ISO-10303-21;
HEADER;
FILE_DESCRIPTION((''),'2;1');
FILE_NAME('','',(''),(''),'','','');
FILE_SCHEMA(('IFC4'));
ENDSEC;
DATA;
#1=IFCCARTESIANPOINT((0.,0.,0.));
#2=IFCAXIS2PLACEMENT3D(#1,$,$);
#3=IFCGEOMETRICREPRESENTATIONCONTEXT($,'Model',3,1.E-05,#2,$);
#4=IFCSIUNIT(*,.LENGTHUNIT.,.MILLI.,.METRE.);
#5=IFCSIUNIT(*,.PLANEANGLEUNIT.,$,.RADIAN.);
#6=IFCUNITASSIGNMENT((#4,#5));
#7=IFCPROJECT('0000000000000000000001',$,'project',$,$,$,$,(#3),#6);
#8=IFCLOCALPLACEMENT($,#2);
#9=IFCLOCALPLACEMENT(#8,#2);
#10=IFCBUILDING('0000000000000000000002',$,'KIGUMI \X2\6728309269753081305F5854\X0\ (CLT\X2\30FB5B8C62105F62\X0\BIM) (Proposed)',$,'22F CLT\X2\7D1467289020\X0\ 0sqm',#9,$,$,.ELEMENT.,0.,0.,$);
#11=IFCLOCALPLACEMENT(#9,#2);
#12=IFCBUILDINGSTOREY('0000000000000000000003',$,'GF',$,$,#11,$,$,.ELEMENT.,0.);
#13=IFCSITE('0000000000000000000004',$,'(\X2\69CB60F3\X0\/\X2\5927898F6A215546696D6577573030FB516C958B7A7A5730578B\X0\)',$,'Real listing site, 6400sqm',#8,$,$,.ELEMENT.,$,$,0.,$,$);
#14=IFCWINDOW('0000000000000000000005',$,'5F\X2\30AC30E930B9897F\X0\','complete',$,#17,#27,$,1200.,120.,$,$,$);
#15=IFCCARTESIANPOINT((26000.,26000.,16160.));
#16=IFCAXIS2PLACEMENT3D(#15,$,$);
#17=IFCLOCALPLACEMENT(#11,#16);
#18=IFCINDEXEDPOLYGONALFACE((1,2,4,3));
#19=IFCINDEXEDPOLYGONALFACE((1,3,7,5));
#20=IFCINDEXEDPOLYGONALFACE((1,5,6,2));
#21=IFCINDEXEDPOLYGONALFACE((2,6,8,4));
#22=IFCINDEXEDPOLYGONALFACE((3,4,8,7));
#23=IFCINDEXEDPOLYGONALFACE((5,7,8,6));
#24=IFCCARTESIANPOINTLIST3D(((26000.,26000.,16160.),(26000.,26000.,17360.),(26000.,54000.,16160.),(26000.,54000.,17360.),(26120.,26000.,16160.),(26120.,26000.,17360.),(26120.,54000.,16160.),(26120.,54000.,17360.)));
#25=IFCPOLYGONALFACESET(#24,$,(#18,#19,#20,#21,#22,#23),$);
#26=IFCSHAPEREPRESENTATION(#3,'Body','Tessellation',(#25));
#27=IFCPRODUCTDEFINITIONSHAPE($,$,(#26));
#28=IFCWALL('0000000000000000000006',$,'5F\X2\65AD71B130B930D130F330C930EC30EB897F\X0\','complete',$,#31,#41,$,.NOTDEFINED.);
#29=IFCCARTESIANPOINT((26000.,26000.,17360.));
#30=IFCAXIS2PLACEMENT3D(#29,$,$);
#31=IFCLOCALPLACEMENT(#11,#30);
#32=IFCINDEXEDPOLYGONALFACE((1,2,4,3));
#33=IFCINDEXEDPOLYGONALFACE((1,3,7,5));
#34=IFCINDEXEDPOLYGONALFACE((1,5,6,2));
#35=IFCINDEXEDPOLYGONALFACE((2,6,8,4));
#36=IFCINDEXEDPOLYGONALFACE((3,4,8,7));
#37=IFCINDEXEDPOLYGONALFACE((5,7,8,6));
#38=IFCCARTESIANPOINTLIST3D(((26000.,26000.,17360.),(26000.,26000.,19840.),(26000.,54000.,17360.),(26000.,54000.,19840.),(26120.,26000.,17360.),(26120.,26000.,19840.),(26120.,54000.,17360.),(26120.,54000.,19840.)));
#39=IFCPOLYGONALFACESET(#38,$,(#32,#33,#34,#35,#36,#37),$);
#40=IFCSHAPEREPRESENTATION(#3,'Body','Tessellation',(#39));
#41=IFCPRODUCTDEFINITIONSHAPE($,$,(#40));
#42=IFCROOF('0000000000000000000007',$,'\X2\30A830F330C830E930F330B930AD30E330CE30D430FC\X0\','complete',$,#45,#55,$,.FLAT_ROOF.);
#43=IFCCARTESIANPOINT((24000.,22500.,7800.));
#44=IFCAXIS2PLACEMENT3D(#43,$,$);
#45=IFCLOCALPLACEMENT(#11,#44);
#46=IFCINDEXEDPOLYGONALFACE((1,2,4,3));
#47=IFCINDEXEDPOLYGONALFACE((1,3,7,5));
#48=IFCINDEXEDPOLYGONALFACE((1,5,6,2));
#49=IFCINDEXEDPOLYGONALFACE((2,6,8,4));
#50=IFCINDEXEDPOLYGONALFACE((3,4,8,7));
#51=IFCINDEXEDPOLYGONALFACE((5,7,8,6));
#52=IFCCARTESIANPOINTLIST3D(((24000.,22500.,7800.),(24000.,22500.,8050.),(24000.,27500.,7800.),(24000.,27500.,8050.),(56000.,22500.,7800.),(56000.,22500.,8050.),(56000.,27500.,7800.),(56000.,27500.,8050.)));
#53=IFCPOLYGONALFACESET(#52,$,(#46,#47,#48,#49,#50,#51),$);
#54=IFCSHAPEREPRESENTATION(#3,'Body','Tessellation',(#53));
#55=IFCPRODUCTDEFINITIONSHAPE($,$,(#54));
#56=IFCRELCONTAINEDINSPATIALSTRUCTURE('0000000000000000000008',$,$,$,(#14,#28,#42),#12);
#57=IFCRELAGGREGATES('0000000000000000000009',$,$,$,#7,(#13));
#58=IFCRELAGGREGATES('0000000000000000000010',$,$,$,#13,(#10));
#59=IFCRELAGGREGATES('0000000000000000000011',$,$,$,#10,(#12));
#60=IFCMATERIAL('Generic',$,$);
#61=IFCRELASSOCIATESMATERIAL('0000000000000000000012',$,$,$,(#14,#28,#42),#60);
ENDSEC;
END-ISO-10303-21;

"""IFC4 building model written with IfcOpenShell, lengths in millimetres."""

from ifc_helpers import new_model, si_unit, frame, frame_2d, origin, place, context, project, spatial, rectangle, extrude, material, element, save


model = new_model("IFC4")

# Units and contexts
model_context = context("Model", 3, precision=1e-05, world=origin())
ifc_project = project(units=[si_unit("LENGTHUNIT", "METRE", prefix="MILLI"), si_unit("PLANEANGLEUNIT", "RADIAN")], contexts=[model_context])

# Site, building, storey
site_placement = place(None, origin())
site = spatial("IfcSite", under=ifc_project, at=site_placement, Name="(構想/大規模商業敷地・公開空地型)", ObjectType="Real listing site, 6400sqm", CompositionType="ELEMENT", RefElevation=0.0)
building_placement = place(site_placement, origin())
building = spatial("IfcBuilding", under=site, at=building_placement, Name="KIGUMI 木を極めた塔 (CLT・完成形BIM) (Proposed)", ObjectType="22F CLT純木造 0sqm", CompositionType="ELEMENT", ElevationOfRefHeight=0.0, ElevationOfTerrain=0.0)
storey_placement = place(building_placement, origin())
storey = spatial("IfcBuildingStorey", under=building, at=storey_placement, Name="GF", CompositionType="ELEMENT", Elevation=0.0)

# Shared definitions
ifc_material = material(Name="Generic")

# Window
window_1_placement = place(storey_placement, frame((26000.0, 26000.0, 16160.0)))
element("IfcWindow", 1, at=window_1_placement, inside=storey, material=ifc_material, Name="5Fガラス西", Description="complete", OverallHeight=1200.0, OverallWidth=120.0, context=model_context, shape_type="SweptSolid", body=[
    extrude(rectangle(XDim=120.0, YDim=28000.0, at=frame_2d((60.0, 14000.0))), frame((26000.0, 26000.0, 16160.0)), (0.0, 0.0, 1.0), 1200.0),
])

# Wall
wall_1_placement = place(storey_placement, frame((26000.0, 26000.0, 17360.0)))
element("IfcWall", 2, at=wall_1_placement, inside=storey, material=ifc_material, Name="5F断熱スパンドレル西", Description="complete", PredefinedType="NOTDEFINED", context=model_context, shape_type="SweptSolid", body=[
    extrude(rectangle(XDim=120.0, YDim=28000.0, at=frame_2d((60.0, 14000.0))), frame((26000.0, 26000.0, 17360.0)), (0.0, 0.0, 1.0), 2480.0),
])

# Roof
roof_placement = place(storey_placement, frame((24000.0, 22500.0, 7800.0)))
element("IfcRoof", 3, at=roof_placement, inside=storey, material=ifc_material, Name="エントランスキャノピー", Description="complete", PredefinedType="FLAT_ROOF", context=model_context, shape_type="SweptSolid", body=[
    extrude(rectangle(XDim=32000.0, YDim=5000.0, at=frame_2d((16000.0, 2500.0))), frame((24000.0, 22500.0, 7800.0)), (0.0, 0.0, 1.0), 250.0),
])

save(model, "model.ifc")
